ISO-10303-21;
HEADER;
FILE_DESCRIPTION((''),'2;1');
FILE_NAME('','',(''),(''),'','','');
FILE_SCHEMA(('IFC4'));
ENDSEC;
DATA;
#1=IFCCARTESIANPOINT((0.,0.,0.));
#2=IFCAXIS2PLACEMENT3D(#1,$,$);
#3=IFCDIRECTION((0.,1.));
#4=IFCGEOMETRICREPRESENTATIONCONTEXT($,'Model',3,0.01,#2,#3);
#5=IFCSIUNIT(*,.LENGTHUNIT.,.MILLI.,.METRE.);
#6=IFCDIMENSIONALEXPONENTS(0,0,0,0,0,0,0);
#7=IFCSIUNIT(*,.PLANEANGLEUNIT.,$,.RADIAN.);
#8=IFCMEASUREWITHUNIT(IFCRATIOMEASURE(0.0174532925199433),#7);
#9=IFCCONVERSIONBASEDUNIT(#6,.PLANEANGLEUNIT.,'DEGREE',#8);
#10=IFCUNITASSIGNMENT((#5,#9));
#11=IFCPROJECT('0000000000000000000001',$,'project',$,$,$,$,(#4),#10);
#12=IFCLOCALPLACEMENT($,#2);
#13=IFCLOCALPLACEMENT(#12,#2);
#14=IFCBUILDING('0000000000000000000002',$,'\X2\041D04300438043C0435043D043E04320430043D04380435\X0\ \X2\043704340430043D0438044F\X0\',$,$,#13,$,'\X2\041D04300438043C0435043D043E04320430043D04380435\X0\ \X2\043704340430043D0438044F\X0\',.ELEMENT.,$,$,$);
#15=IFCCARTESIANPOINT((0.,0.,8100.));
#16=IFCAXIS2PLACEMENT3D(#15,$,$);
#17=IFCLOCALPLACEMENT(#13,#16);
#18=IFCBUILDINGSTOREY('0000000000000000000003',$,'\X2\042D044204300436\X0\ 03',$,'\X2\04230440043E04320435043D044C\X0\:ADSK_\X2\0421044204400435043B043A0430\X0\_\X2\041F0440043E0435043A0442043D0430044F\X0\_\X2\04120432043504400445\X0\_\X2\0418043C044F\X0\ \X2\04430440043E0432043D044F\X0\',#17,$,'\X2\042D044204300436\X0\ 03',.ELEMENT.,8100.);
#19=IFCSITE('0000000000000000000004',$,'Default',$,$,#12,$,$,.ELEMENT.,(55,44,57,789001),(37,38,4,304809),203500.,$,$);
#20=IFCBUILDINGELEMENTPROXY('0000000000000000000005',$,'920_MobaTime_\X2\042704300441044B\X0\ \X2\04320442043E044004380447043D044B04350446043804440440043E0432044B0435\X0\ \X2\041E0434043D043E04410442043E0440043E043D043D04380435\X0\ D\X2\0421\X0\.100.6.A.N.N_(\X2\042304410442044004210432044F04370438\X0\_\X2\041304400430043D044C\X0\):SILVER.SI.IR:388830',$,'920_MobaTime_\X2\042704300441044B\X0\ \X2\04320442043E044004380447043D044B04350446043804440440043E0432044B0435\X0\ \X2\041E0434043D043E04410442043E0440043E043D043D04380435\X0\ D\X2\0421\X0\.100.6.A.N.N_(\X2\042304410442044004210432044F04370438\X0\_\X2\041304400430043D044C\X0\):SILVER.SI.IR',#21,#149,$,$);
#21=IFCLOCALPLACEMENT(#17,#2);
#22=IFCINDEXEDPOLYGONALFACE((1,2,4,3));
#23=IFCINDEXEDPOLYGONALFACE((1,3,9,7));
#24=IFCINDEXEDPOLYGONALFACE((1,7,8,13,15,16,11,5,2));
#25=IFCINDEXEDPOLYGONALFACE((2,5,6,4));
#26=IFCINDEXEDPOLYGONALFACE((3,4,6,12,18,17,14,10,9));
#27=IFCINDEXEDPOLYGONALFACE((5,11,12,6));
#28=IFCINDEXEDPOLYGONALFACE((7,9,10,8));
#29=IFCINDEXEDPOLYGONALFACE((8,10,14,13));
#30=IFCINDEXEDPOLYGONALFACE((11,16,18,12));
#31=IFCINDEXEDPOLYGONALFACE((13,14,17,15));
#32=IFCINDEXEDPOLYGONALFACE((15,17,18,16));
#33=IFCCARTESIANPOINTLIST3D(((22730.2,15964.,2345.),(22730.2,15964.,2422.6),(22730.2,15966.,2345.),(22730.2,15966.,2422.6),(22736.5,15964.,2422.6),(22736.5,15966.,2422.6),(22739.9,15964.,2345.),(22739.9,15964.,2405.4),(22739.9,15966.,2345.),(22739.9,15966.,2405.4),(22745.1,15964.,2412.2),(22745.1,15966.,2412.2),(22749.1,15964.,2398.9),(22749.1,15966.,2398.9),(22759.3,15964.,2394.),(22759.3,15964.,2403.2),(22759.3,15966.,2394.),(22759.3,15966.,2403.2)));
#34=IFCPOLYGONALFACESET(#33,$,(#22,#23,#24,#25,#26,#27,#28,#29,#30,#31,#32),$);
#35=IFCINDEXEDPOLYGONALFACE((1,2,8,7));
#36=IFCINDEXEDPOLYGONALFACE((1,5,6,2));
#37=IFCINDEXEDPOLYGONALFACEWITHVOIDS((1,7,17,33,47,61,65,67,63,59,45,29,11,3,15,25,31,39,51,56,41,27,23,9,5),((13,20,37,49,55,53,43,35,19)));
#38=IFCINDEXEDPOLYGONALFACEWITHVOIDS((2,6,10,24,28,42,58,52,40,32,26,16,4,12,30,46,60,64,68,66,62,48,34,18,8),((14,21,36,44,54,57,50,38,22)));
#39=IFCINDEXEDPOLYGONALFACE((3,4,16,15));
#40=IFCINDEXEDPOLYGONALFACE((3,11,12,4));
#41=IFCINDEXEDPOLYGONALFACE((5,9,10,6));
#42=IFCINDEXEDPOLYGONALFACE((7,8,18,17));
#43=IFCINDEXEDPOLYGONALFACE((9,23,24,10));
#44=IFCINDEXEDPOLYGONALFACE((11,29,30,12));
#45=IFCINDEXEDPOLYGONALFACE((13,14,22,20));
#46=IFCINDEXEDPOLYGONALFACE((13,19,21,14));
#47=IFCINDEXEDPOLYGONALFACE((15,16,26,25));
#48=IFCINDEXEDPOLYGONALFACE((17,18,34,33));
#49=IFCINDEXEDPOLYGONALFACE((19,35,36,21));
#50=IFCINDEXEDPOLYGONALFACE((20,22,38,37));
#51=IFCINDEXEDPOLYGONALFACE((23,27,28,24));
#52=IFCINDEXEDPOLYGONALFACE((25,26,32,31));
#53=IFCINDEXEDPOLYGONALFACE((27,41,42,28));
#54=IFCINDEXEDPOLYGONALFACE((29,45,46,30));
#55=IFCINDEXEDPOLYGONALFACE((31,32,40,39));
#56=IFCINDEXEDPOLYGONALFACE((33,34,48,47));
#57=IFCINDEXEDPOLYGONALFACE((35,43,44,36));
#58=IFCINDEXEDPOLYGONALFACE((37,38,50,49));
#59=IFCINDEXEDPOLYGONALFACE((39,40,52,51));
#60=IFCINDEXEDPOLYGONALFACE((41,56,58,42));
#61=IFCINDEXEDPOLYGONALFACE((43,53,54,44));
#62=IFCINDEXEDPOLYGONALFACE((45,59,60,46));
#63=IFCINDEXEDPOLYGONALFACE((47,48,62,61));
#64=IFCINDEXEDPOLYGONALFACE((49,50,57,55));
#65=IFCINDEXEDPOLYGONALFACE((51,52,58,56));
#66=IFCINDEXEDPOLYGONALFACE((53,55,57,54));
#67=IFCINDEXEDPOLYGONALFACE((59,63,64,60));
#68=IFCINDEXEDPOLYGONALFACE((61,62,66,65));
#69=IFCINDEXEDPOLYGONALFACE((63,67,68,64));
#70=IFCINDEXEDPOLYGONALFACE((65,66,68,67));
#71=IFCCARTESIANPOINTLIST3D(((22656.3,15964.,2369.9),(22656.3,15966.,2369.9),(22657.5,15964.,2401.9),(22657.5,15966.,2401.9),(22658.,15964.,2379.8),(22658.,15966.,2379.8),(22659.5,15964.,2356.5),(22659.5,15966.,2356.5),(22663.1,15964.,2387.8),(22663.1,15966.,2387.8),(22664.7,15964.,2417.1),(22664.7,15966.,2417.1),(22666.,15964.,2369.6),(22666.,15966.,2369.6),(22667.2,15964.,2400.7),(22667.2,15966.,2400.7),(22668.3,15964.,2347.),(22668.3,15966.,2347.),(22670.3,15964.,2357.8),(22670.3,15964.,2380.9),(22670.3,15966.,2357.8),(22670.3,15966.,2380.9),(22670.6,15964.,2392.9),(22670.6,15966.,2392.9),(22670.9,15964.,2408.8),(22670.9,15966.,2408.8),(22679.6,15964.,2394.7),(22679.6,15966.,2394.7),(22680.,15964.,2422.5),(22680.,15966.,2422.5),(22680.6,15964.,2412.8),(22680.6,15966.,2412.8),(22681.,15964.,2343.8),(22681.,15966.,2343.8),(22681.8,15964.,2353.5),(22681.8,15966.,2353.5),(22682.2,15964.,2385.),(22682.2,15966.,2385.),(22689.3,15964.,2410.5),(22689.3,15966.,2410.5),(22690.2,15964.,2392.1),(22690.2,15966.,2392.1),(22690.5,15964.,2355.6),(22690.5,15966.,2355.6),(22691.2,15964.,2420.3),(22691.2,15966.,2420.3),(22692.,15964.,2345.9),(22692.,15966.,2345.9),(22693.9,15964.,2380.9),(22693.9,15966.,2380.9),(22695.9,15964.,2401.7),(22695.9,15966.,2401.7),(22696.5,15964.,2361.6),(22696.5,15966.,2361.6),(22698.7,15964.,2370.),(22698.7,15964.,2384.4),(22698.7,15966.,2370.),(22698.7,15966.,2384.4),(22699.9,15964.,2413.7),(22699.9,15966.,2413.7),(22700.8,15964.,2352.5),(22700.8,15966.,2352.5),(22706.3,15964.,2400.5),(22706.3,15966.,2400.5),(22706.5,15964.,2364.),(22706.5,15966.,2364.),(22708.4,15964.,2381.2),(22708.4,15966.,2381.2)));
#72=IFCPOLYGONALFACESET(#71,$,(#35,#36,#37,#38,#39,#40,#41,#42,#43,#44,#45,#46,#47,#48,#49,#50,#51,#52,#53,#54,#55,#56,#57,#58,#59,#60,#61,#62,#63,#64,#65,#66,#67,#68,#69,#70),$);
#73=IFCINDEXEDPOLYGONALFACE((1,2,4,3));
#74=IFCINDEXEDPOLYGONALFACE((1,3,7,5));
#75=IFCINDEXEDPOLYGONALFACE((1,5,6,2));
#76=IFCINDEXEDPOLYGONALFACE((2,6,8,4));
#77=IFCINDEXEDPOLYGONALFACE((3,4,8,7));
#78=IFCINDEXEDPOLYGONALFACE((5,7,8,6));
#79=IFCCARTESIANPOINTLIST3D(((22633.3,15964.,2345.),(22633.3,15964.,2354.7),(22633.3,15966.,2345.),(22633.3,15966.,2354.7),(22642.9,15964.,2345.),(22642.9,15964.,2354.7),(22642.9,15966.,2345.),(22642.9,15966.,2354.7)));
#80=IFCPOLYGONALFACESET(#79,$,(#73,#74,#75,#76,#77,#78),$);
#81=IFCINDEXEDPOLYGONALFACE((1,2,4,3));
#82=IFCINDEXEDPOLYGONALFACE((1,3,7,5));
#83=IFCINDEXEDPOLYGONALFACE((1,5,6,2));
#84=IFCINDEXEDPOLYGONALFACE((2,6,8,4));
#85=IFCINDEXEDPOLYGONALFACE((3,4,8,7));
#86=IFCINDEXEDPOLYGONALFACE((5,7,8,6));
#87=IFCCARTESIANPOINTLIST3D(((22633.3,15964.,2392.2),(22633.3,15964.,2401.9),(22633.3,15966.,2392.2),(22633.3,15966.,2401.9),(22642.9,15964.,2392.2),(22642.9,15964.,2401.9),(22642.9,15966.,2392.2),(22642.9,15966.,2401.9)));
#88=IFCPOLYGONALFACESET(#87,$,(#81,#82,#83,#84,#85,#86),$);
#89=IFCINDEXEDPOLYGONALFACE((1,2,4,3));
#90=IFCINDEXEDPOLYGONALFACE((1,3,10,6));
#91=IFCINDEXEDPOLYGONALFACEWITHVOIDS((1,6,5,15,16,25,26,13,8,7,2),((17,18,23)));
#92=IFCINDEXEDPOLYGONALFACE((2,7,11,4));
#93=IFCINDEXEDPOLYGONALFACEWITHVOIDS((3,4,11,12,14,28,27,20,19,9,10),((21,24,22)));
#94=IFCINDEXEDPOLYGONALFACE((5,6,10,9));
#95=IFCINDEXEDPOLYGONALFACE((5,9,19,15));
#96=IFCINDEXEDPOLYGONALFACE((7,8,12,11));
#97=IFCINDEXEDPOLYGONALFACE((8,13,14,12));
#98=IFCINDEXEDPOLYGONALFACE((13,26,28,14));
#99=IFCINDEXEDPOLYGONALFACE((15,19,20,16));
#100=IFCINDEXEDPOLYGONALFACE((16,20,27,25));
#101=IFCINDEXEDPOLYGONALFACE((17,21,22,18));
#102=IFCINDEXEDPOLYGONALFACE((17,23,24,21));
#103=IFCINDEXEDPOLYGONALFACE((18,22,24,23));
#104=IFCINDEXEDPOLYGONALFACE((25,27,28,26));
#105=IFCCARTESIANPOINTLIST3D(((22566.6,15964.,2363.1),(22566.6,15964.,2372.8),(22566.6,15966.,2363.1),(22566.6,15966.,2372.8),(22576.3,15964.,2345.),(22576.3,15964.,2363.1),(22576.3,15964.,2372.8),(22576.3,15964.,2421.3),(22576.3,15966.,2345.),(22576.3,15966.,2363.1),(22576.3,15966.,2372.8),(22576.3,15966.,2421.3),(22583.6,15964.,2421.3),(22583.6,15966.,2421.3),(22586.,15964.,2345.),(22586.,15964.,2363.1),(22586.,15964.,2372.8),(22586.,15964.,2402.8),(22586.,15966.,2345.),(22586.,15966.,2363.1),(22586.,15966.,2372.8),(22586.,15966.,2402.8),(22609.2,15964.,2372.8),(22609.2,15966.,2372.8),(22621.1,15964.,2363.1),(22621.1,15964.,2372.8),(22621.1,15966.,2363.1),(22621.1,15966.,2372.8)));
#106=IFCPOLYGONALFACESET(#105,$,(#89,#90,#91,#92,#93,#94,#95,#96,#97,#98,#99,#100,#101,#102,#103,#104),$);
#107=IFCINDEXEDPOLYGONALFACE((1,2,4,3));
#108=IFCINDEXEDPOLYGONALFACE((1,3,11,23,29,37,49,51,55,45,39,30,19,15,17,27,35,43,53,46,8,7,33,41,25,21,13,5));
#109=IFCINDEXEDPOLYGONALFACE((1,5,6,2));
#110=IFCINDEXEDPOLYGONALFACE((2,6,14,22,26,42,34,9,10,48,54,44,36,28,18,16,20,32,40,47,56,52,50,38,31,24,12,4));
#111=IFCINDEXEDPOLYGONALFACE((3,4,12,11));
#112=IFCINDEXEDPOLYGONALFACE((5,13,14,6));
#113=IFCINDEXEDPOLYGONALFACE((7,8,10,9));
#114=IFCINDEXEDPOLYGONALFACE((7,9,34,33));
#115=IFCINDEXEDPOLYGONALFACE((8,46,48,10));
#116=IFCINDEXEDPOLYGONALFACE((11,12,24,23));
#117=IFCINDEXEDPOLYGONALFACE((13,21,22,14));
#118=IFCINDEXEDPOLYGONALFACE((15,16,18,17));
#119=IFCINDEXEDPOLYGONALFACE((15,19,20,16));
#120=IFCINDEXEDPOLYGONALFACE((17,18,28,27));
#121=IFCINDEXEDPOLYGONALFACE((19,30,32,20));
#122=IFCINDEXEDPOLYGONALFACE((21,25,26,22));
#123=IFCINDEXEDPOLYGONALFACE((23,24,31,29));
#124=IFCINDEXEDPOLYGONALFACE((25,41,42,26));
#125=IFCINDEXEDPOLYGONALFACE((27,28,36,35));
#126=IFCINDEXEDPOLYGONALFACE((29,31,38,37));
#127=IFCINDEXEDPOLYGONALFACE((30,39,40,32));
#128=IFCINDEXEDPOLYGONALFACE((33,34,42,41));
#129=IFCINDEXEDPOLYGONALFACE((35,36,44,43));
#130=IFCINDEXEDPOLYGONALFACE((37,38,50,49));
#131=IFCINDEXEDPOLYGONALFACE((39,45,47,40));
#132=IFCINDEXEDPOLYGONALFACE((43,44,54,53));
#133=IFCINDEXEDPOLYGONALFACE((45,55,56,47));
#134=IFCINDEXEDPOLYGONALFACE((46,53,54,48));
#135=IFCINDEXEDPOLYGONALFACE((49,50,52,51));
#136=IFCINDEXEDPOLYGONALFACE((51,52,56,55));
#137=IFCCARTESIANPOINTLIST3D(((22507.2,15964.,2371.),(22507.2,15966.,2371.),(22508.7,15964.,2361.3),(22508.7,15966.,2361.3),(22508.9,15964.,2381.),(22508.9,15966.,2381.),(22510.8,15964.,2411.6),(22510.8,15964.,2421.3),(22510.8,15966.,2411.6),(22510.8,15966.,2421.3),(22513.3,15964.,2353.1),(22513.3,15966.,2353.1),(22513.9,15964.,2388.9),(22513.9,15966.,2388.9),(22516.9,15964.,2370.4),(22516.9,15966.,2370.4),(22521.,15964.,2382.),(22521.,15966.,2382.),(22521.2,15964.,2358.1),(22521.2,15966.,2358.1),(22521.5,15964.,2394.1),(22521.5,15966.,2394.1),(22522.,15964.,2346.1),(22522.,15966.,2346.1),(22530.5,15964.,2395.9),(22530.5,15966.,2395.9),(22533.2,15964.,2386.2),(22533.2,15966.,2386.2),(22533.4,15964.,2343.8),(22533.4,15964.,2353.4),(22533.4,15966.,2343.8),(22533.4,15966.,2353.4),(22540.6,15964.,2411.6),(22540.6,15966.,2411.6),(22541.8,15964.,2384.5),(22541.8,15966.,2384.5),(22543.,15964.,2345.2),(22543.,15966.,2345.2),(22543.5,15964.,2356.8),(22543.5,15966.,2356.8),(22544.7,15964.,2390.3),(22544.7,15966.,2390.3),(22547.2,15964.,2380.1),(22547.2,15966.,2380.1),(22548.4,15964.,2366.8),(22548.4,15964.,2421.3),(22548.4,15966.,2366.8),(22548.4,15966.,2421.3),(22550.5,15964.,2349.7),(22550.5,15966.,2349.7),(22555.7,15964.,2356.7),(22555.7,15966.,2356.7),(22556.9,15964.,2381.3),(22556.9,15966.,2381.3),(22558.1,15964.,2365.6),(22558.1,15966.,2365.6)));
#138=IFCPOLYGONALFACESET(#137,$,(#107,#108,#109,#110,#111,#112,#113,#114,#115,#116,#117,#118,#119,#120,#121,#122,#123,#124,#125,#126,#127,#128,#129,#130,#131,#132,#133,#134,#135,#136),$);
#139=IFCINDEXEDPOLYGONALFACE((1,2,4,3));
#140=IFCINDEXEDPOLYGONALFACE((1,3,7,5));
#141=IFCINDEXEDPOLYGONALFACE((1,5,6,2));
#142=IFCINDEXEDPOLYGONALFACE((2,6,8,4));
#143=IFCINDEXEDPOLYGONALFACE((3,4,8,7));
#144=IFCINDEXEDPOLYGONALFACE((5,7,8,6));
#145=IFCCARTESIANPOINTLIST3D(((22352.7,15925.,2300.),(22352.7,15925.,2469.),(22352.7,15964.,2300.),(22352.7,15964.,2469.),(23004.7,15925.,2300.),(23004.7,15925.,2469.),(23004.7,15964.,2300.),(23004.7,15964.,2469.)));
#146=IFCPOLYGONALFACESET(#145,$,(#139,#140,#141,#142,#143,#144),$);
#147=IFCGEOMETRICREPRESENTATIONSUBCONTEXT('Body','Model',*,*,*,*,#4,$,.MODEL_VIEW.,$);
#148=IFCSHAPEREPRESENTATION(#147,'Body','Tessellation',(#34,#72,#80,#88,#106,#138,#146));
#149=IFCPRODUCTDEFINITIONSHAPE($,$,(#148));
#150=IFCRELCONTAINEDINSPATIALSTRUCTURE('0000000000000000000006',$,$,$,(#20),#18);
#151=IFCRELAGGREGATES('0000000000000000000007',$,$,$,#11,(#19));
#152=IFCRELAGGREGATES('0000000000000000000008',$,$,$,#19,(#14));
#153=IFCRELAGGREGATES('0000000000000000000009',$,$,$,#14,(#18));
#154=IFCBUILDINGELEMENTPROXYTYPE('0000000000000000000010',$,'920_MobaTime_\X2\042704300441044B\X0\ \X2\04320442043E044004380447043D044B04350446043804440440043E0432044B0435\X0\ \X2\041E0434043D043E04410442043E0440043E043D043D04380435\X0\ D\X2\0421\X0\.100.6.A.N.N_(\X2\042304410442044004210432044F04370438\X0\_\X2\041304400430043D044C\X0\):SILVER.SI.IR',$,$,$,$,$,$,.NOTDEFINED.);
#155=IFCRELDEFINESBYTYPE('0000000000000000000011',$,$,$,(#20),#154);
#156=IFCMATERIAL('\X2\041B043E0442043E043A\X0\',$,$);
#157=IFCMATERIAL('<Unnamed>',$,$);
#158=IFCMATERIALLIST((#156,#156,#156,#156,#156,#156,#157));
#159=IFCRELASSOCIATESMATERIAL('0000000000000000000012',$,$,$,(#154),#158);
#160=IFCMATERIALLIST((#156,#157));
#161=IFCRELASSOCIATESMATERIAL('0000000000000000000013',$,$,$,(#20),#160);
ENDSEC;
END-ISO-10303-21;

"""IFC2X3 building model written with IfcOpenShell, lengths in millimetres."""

from ifc_helpers import new_model, entity, si_unit, converted_unit, direction, frame, origin, origin_2d_with_axis, place, context, subcontext, project, spatial, polyline, rectangle, outline, extrude, source, transform, mapped, material, material_list, type_object, type_shapes, element, save


model = new_model("IFC2X3")

# Units and contexts
model_context = context("Model", 3, precision=0.01, world=origin(), true_north=direction((0.0, 1.0)))
body_context = subcontext(model_context, "Body", "Model", "MODEL_VIEW")
ifc_project = project(units=[si_unit("LENGTHUNIT", "METRE", prefix="MILLI"), converted_unit("PLANEANGLEUNIT", "DEGREE", entity("IfcRatioMeasure", 0.0174532925199433), si_unit("PLANEANGLEUNIT", "RADIAN"), dimensions=[0, 0, 0, 0, 0, 0, 0])], contexts=[model_context])

# Site, building, storey
site_placement = place(None, origin())
site = spatial("IfcSite", under=ifc_project, at=site_placement, Name="Default", CompositionType="ELEMENT", RefLatitude=(55, 44, 57, 789001), RefLongitude=(37, 38, 4, 304809), RefElevation=203500.0)
building_placement = place(site_placement, origin())
building = spatial("IfcBuilding", under=site, at=building_placement, Name="Наименование здания", LongName="Наименование здания", CompositionType="ELEMENT")
storey_placement = place(building_placement, frame((0.0, 0.0, 8100.0)))
storey = spatial("IfcBuildingStorey", under=building, at=storey_placement, Name="Этаж 03", ObjectType="Уровень:ADSK_Стрелка_Проектная_Вверх_Имя уровня", LongName="Этаж 03", CompositionType="ELEMENT", Elevation=8100.0)

# Building element proxy
ifc_material_1 = material(Name="Лоток")
ifc_material_2 = material(Name="<Unnamed>")
ifc_material_list_1 = material_list([ifc_material_1, ifc_material_1, ifc_material_1, ifc_material_1, ifc_material_1, ifc_material_1, ifc_material_2])
building_element_proxy_type = type_object("IfcBuildingElementProxyType", Name="920_MobaTime_Часы вторичныецифровые Односторонние DС.100.6.A.N.N_(УстрСвязи_Грань):SILVER.SI.IR", PredefinedType="NOTDEFINED", material=ifc_material_list_1)
shared_shape = source(origin(), body_context, "Body", "SweptSolid", [
    extrude(outline(polyline([(-49.3, -13.1), (28.2, -13.1), (28.2, -6.8), (17.9, 1.8), (8.8, 16.0), (-0.3, 16.0), (4.6, 5.8), (11.1, -3.4), (-49.3, -3.4), (-49.3, -13.1)])), frame((-64.6, 9.8, 39.0), z_axis=(0.0, 0.0, 1.0), x_axis=(0.0, 1.0, 0.0)), (0.0, 0.0, 1.0), 2.0),
    extrude(outline(polyline([(2.2, -27.6), (19.0, -27.6), (30.5, -16.1), (33.3, -4.9), (31.0, 5.8), (21.8, 17.2), (5.2, 27.3), (-11.1, 33.0), (-24.0, 32.7), (-33.6, 27.6), (-40.3, 18.6), (-42.8, 5.7), (-38.0, -6.3), (-27.2, -14.9), (-17.5, -17.7), (-8.2, -16.4), (-0.3, -11.9), (5.1, -4.5), (7.3, 6.2), (4.0, 17.2), (18.4, 7.3), (23.6, -2.4), (22.0, -11.4), (14.2, -18.4), (5.3, -18.3), (2.2, -27.6)]), holes=[polyline([(-9.0, 23.3), (-1.3, 14.3), (-2.5, 2.0), (-11.4, -7.0), (-23.4, -6.0), (-32.2, 2.9), (-31.2, 15.1), (-25.6, 22.1), (-17.5, 24.9), (-9.0, 23.3)])]), frame((-2.7, 3.6, 39.0), z_axis=(0.0, 0.0, 1.0), x_axis=(-0.427649, 0.903945, 0.0)), (0.0, 0.0, 1.0), 2.0),
    extrude(rectangle(XDim=9.7, YDim=9.7, at=origin_2d_with_axis()), frame((40.6, -34.7, 39.0)), (0.0, 0.0, 1.0), 2.0),
    extrude(rectangle(XDim=9.7, YDim=9.7, at=origin_2d_with_axis()), frame((40.6, 12.6, 39.0)), (0.0, 0.0, 1.0), 2.0),
    extrude(outline(polyline([(-0.9, -28.1), (8.8, -28.1), (8.8, -9.9), (18.5, -9.9), (18.5, -0.2), (8.8, -0.2), (8.8, 48.3), (1.5, 48.3), (-36.0, -0.2), (-36.0, -9.9), (-0.9, -9.9), (-0.9, -28.1)]), holes=[polyline([(-0.9, -0.2), (-24.1, -0.2), (-0.9, 29.7), (-0.9, -0.2)])]), frame((93.6, -11.4, 39.0)), (0.0, 0.0, 1.0), 2.0),
    extrude(outline(polyline([(3.3, -28.3), (12.5, -28.3), (20.5, -25.0), (26.8, -18.9), (30.7, -10.0), (31.4, 1.6), (26.9, 11.8), (20.1, 18.4), (11.1, 22.3), (1.0, 23.3), (-7.9, 20.4), (-14.9, 14.5), (-18.9, 6.2), (-17.1, -9.0), (-36.7, 0.5), (-29.1, 29.2), (-38.5, 31.7), (-48.1, -4.6), (-11.6, -23.1), (-8.0, -14.0), (-10.8, -7.6), (-10.2, 1.1), (-3.0, 11.8), (9.2, 12.8), (20.0, 5.5), (21.4, -7.5), (15.5, -16.4), (4.6, -18.6), (3.3, -28.3)])), frame((147.1, -8.5, 39.0), z_axis=(0.0, 0.0, 1.0), x_axis=(0.256974, -0.966418, 0.0)), (0.0, 0.0, 1.0), 2.0),
    extrude(rectangle(XDim=652.0, YDim=169.0, at=origin_2d_with_axis()), frame((0.0, 0.0, 0.0), z_axis=(0.0, 0.0, 1.0), x_axis=(-1.0, 0.0, 0.0)), (0.0, 0.0, 1.0), 39.0),
])
type_shapes(building_element_proxy_type, [shared_shape])
ifc_material_list_2 = material_list([ifc_material_1, ifc_material_2])
for number, where, z_axis, x_axis, name in (
    (1, (22678.7, 15925.0, 2384.5), (0.0, 1.0, 0.0), (-1.0, 0.0, 0.0), "920_MobaTime_Часы вторичныецифровые Односторонние DС.100.6.A.N.N_(УстрСвязи_Грань):SILVER.SI.IR:388830"),
):
    element("IfcBuildingElementProxy", number, at=place(storey_placement, frame(where, z_axis=z_axis, x_axis=x_axis)), inside=storey, type_object=building_element_proxy_type, material=ifc_material_list_2, Name=name, ObjectType="920_MobaTime_Часы вторичныецифровые Односторонние DС.100.6.A.N.N_(УстрСвязи_Грань):SILVER.SI.IR", context=body_context, shape_type="MappedRepresentation", body=[
        mapped(shared_shape, transform((0.0, 0.0, 0.0), scale=1.0)),
    ])

save(model, "model.ifc")
